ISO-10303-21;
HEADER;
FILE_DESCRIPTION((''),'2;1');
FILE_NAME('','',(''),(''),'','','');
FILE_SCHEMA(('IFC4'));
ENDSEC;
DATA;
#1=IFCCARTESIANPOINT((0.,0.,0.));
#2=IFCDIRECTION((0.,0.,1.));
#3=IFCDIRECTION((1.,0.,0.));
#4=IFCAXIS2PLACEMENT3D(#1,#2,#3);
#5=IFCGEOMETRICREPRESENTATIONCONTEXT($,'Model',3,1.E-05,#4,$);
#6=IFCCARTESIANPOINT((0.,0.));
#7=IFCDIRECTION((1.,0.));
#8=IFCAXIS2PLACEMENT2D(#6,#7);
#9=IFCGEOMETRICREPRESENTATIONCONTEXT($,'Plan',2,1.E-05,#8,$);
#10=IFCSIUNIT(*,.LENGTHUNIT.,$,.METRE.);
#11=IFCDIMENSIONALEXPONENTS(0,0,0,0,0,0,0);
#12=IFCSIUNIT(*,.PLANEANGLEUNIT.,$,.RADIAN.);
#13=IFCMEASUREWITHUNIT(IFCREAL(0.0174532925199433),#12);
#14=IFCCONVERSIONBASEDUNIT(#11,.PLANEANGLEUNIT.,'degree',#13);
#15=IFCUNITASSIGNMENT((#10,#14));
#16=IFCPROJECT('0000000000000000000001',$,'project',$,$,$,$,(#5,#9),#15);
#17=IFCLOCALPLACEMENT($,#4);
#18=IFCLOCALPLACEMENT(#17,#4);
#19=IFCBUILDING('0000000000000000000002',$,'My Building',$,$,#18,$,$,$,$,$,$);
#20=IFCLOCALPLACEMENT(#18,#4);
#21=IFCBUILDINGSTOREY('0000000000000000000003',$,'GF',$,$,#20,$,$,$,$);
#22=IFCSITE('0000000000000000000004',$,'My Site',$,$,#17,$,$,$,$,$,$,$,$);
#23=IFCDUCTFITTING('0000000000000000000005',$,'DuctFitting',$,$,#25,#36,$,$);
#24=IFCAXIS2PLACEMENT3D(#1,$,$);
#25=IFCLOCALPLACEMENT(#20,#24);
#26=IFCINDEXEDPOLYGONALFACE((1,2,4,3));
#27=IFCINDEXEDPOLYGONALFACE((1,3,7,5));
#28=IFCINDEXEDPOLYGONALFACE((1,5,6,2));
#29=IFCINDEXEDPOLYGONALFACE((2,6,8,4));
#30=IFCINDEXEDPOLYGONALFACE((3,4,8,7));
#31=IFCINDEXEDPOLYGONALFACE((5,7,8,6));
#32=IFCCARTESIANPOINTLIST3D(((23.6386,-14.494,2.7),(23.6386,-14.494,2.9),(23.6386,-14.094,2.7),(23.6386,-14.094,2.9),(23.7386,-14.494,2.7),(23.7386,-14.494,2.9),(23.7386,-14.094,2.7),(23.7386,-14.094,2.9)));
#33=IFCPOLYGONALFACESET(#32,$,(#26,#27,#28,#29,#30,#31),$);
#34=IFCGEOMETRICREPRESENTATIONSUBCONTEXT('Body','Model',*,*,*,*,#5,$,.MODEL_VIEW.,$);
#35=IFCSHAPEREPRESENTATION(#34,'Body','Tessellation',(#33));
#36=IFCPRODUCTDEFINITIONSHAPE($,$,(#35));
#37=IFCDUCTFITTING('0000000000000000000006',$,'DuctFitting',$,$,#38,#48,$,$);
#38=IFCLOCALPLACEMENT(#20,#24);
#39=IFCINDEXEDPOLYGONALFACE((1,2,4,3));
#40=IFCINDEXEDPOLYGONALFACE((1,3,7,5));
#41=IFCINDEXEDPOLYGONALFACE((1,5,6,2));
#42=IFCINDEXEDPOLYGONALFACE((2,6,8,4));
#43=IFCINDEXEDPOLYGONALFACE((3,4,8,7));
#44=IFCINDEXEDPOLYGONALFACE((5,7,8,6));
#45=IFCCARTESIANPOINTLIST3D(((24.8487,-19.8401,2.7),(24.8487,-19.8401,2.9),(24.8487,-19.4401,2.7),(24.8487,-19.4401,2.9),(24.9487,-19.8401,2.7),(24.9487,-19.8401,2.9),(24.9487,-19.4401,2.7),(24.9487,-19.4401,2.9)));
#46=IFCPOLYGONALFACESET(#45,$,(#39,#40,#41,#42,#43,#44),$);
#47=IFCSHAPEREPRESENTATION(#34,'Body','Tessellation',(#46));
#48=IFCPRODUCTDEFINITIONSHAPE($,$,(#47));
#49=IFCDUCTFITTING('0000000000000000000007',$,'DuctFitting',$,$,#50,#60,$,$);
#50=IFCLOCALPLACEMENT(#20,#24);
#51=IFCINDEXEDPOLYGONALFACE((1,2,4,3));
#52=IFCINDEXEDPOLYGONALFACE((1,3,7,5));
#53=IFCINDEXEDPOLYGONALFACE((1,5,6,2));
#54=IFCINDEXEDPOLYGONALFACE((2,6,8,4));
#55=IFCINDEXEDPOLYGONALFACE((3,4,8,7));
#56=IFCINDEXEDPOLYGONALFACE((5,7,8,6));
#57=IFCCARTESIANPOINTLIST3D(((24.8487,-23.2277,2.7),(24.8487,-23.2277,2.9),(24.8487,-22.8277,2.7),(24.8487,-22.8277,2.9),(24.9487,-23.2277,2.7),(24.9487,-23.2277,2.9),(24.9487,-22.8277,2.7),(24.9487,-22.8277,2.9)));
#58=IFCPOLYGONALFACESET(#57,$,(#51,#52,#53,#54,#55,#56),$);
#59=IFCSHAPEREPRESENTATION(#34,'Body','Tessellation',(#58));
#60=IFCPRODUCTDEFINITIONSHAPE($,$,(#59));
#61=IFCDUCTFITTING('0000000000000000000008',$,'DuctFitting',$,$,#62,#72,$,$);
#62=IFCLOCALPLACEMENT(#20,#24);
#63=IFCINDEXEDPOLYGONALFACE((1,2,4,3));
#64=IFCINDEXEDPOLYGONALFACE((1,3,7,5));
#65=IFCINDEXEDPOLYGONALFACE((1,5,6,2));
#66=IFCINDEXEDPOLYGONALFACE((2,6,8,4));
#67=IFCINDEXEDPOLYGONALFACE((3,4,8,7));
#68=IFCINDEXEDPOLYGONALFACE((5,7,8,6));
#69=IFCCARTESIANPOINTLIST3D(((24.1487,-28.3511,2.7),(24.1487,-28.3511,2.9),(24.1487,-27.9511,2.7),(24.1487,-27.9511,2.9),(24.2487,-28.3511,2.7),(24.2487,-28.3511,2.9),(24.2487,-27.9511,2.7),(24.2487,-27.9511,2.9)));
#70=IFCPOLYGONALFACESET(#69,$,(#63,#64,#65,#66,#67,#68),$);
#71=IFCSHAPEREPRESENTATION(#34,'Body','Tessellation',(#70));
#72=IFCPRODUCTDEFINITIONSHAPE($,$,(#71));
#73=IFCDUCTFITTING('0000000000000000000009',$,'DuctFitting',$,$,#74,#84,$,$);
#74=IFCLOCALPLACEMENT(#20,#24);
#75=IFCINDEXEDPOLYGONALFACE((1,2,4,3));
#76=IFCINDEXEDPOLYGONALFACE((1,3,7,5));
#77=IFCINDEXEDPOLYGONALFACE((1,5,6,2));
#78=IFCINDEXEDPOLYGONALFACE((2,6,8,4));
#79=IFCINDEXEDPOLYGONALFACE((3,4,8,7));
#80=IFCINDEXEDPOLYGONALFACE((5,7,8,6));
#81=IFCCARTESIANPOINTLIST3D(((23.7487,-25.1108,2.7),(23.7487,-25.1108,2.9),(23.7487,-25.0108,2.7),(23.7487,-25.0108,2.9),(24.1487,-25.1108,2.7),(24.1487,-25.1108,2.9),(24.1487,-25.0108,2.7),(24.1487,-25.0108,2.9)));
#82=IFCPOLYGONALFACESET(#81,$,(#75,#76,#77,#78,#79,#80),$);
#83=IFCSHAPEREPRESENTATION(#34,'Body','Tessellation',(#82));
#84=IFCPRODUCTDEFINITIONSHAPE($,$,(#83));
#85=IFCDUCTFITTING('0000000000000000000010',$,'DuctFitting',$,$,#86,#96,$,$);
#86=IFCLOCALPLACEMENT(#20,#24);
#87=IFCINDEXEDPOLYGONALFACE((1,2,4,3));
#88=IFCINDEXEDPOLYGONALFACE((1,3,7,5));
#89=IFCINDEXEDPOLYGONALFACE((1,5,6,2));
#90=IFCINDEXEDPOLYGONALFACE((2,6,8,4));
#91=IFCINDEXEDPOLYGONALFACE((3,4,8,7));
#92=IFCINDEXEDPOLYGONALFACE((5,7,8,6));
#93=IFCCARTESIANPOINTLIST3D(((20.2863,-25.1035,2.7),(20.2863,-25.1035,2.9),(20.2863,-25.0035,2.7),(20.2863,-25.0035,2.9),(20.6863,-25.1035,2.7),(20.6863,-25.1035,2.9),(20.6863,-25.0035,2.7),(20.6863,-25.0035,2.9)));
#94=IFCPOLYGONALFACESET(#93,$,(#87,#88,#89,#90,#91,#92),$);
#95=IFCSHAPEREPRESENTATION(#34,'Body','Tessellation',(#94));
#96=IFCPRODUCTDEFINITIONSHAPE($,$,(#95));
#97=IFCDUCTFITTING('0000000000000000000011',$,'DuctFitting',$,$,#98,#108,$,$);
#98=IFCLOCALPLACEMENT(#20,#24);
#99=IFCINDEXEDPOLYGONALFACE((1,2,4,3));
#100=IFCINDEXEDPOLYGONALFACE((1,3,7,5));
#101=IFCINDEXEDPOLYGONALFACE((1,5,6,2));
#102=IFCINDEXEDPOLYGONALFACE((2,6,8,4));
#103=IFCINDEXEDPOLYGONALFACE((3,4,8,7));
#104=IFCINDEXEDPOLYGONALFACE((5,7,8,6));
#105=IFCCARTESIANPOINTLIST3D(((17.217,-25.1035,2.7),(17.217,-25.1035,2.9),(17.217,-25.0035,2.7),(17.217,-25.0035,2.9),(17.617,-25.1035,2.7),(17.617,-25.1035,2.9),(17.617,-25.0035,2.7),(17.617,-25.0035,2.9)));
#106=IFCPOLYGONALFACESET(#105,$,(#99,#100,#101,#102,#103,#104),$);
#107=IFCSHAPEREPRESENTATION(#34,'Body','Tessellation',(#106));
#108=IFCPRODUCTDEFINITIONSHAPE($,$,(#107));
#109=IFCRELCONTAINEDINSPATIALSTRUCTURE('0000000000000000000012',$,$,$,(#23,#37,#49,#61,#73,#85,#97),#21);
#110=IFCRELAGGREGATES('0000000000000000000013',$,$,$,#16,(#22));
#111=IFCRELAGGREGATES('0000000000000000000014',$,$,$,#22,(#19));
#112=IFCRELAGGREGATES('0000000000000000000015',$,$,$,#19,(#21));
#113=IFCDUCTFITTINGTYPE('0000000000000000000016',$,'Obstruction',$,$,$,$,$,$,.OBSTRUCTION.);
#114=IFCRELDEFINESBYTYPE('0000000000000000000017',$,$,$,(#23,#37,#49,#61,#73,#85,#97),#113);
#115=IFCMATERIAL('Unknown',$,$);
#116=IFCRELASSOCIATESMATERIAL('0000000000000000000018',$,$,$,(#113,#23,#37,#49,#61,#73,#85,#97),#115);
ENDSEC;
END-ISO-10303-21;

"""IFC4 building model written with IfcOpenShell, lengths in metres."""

from ifc_helpers import new_model, entity, si_unit, converted_unit, frame, origin_with_axes, origin_2d_with_axis, place, context, subcontext, project, spatial, rectangle, extrude, material, material_profile, profile_set, profile_usage, type_object, element, save


model = new_model("IFC4")

# Units and contexts
model_context = context("Model", 3, precision=1e-05, world=origin_with_axes())
plan_context = context("Plan", 2, precision=1e-05, world=origin_2d_with_axis())
body_context_1 = subcontext(model_context, "Body", "Model", "MODEL_VIEW")
ifc_project = project(units=[si_unit("LENGTHUNIT", "METRE"), converted_unit("PLANEANGLEUNIT", "degree", entity("IfcReal", 0.0174532925199433), si_unit("PLANEANGLEUNIT", "RADIAN"), dimensions=[0, 0, 0, 0, 0, 0, 0])], contexts=[model_context, plan_context])

# Site, building, storey
site_placement = place(None, origin_with_axes())
site = spatial("IfcSite", under=ifc_project, at=site_placement, Name="My Site")
building_placement = place(site_placement, origin_with_axes())
building = spatial("IfcBuilding", under=site, at=building_placement, Name="My Building")
storey_placement = place(building_placement, origin_with_axes())
storey = spatial("IfcBuildingStorey", under=building, at=storey_placement, Name="GF")

# Shared definitions
ifc_material = material(Name="Unknown")

# Duct fittings
ifc_material_profile_1 = material_profile(ifc_material, rectangle(XDim=0.4, YDim=0.2))
ifc_profile_set_1 = profile_set([ifc_material_profile_1])
duct_fitting_type = type_object("IfcDuctFittingType", Name="Obstruction", PredefinedType="OBSTRUCTION", material=ifc_profile_set_1)
ifc_profile_usage_1 = profile_usage(ifc_profile_set_1, cardinal=5)
duct_fitting_1_placement = place(storey_placement, frame((23.7386, -14.294, 2.8), z_axis=(-1.0, 0.0, 0.0), x_axis=(0.0, -1.0, 0.0)))
element("IfcDuctFitting", 1, at=duct_fitting_1_placement, inside=storey, type_object=duct_fitting_type, material=ifc_profile_usage_1, Name="DuctFitting", context=body_context_1, shape_type="SweptSolid", body=[
    extrude(rectangle(XDim=0.4, YDim=0.2), origin_with_axes(), (0.0, 0.0, 1.0), 0.1),
])
ifc_profile_usage_2 = profile_usage(ifc_profile_set_1, cardinal=5)
duct_fitting_2_placement = place(storey_placement, frame((24.9487, -19.6401, 2.8), z_axis=(-1.0, 0.0, 0.0), x_axis=(0.0, -1.0, 0.0)))
element("IfcDuctFitting", 2, at=duct_fitting_2_placement, inside=storey, type_object=duct_fitting_type, material=ifc_profile_usage_2, Name="DuctFitting", context=body_context_1, shape_type="SweptSolid", body=[
    extrude(rectangle(XDim=0.4, YDim=0.2), origin_with_axes(), (0.0, 0.0, 1.0), 0.1),
])
ifc_profile_usage_3 = profile_usage(ifc_profile_set_1, cardinal=5)
duct_fitting_3_placement = place(storey_placement, frame((24.9487, -23.0277, 2.8), z_axis=(-1.0, 0.0, 0.0), x_axis=(0.0, -1.0, 0.0)))
element("IfcDuctFitting", 3, at=duct_fitting_3_placement, inside=storey, type_object=duct_fitting_type, material=ifc_profile_usage_3, Name="DuctFitting", context=body_context_1, shape_type="SweptSolid", body=[
    extrude(rectangle(XDim=0.4, YDim=0.2), origin_with_axes(), (0.0, 0.0, 1.0), 0.1),
])
ifc_profile_usage_4 = profile_usage(ifc_profile_set_1, cardinal=5)
duct_fitting_4_placement = place(storey_placement, frame((24.2487, -28.1511, 2.8), z_axis=(-1.0, 0.0, 0.0), x_axis=(0.0, -1.0, 0.0)))
element("IfcDuctFitting", 4, at=duct_fitting_4_placement, inside=storey, type_object=duct_fitting_type, material=ifc_profile_usage_4, Name="DuctFitting", context=body_context_1, shape_type="SweptSolid", body=[
    extrude(rectangle(XDim=0.4, YDim=0.2), origin_with_axes(), (0.0, 0.0, 1.0), 0.1),
])
ifc_profile_usage_5 = profile_usage(ifc_profile_set_1, cardinal=5)
duct_fitting_5_placement = place(storey_placement, frame((23.9487, -25.1108, 2.8), z_axis=(0.0, 1.0, 0.0), x_axis=(-1.0, 0.0, 0.0)))
element("IfcDuctFitting", 5, at=duct_fitting_5_placement, inside=storey, type_object=duct_fitting_type, material=ifc_profile_usage_5, Name="DuctFitting", context=body_context_1, shape_type="SweptSolid", body=[
    extrude(rectangle(XDim=0.4, YDim=0.2), origin_with_axes(), (0.0, 0.0, 1.0), 0.1),
])
ifc_profile_usage_6 = profile_usage(ifc_profile_set_1, cardinal=5)
duct_fitting_6_placement = place(storey_placement, frame((20.4863, -25.1035, 2.8), z_axis=(0.0, 1.0, 0.0), x_axis=(-1.0, 0.0, 0.0)))
element("IfcDuctFitting", 6, at=duct_fitting_6_placement, inside=storey, type_object=duct_fitting_type, material=ifc_profile_usage_6, Name="DuctFitting", context=body_context_1, shape_type="SweptSolid", body=[
    extrude(rectangle(XDim=0.4, YDim=0.2), origin_with_axes(), (0.0, 0.0, 1.0), 0.1),
])
ifc_profile_usage_7 = profile_usage(ifc_profile_set_1, cardinal=5)
duct_fitting_7_placement = place(storey_placement, frame((17.417, -25.1035, 2.8), z_axis=(0.0, 1.0, 0.0), x_axis=(-1.0, 0.0, 0.0)))
element("IfcDuctFitting", 7, at=duct_fitting_7_placement, inside=storey, type_object=duct_fitting_type, material=ifc_profile_usage_7, Name="DuctFitting", context=body_context_1, shape_type="SweptSolid", body=[
    extrude(rectangle(XDim=0.4, YDim=0.2), origin_with_axes(), (0.0, 0.0, 1.0), 0.1),
])

save(model, "model.ifc")
